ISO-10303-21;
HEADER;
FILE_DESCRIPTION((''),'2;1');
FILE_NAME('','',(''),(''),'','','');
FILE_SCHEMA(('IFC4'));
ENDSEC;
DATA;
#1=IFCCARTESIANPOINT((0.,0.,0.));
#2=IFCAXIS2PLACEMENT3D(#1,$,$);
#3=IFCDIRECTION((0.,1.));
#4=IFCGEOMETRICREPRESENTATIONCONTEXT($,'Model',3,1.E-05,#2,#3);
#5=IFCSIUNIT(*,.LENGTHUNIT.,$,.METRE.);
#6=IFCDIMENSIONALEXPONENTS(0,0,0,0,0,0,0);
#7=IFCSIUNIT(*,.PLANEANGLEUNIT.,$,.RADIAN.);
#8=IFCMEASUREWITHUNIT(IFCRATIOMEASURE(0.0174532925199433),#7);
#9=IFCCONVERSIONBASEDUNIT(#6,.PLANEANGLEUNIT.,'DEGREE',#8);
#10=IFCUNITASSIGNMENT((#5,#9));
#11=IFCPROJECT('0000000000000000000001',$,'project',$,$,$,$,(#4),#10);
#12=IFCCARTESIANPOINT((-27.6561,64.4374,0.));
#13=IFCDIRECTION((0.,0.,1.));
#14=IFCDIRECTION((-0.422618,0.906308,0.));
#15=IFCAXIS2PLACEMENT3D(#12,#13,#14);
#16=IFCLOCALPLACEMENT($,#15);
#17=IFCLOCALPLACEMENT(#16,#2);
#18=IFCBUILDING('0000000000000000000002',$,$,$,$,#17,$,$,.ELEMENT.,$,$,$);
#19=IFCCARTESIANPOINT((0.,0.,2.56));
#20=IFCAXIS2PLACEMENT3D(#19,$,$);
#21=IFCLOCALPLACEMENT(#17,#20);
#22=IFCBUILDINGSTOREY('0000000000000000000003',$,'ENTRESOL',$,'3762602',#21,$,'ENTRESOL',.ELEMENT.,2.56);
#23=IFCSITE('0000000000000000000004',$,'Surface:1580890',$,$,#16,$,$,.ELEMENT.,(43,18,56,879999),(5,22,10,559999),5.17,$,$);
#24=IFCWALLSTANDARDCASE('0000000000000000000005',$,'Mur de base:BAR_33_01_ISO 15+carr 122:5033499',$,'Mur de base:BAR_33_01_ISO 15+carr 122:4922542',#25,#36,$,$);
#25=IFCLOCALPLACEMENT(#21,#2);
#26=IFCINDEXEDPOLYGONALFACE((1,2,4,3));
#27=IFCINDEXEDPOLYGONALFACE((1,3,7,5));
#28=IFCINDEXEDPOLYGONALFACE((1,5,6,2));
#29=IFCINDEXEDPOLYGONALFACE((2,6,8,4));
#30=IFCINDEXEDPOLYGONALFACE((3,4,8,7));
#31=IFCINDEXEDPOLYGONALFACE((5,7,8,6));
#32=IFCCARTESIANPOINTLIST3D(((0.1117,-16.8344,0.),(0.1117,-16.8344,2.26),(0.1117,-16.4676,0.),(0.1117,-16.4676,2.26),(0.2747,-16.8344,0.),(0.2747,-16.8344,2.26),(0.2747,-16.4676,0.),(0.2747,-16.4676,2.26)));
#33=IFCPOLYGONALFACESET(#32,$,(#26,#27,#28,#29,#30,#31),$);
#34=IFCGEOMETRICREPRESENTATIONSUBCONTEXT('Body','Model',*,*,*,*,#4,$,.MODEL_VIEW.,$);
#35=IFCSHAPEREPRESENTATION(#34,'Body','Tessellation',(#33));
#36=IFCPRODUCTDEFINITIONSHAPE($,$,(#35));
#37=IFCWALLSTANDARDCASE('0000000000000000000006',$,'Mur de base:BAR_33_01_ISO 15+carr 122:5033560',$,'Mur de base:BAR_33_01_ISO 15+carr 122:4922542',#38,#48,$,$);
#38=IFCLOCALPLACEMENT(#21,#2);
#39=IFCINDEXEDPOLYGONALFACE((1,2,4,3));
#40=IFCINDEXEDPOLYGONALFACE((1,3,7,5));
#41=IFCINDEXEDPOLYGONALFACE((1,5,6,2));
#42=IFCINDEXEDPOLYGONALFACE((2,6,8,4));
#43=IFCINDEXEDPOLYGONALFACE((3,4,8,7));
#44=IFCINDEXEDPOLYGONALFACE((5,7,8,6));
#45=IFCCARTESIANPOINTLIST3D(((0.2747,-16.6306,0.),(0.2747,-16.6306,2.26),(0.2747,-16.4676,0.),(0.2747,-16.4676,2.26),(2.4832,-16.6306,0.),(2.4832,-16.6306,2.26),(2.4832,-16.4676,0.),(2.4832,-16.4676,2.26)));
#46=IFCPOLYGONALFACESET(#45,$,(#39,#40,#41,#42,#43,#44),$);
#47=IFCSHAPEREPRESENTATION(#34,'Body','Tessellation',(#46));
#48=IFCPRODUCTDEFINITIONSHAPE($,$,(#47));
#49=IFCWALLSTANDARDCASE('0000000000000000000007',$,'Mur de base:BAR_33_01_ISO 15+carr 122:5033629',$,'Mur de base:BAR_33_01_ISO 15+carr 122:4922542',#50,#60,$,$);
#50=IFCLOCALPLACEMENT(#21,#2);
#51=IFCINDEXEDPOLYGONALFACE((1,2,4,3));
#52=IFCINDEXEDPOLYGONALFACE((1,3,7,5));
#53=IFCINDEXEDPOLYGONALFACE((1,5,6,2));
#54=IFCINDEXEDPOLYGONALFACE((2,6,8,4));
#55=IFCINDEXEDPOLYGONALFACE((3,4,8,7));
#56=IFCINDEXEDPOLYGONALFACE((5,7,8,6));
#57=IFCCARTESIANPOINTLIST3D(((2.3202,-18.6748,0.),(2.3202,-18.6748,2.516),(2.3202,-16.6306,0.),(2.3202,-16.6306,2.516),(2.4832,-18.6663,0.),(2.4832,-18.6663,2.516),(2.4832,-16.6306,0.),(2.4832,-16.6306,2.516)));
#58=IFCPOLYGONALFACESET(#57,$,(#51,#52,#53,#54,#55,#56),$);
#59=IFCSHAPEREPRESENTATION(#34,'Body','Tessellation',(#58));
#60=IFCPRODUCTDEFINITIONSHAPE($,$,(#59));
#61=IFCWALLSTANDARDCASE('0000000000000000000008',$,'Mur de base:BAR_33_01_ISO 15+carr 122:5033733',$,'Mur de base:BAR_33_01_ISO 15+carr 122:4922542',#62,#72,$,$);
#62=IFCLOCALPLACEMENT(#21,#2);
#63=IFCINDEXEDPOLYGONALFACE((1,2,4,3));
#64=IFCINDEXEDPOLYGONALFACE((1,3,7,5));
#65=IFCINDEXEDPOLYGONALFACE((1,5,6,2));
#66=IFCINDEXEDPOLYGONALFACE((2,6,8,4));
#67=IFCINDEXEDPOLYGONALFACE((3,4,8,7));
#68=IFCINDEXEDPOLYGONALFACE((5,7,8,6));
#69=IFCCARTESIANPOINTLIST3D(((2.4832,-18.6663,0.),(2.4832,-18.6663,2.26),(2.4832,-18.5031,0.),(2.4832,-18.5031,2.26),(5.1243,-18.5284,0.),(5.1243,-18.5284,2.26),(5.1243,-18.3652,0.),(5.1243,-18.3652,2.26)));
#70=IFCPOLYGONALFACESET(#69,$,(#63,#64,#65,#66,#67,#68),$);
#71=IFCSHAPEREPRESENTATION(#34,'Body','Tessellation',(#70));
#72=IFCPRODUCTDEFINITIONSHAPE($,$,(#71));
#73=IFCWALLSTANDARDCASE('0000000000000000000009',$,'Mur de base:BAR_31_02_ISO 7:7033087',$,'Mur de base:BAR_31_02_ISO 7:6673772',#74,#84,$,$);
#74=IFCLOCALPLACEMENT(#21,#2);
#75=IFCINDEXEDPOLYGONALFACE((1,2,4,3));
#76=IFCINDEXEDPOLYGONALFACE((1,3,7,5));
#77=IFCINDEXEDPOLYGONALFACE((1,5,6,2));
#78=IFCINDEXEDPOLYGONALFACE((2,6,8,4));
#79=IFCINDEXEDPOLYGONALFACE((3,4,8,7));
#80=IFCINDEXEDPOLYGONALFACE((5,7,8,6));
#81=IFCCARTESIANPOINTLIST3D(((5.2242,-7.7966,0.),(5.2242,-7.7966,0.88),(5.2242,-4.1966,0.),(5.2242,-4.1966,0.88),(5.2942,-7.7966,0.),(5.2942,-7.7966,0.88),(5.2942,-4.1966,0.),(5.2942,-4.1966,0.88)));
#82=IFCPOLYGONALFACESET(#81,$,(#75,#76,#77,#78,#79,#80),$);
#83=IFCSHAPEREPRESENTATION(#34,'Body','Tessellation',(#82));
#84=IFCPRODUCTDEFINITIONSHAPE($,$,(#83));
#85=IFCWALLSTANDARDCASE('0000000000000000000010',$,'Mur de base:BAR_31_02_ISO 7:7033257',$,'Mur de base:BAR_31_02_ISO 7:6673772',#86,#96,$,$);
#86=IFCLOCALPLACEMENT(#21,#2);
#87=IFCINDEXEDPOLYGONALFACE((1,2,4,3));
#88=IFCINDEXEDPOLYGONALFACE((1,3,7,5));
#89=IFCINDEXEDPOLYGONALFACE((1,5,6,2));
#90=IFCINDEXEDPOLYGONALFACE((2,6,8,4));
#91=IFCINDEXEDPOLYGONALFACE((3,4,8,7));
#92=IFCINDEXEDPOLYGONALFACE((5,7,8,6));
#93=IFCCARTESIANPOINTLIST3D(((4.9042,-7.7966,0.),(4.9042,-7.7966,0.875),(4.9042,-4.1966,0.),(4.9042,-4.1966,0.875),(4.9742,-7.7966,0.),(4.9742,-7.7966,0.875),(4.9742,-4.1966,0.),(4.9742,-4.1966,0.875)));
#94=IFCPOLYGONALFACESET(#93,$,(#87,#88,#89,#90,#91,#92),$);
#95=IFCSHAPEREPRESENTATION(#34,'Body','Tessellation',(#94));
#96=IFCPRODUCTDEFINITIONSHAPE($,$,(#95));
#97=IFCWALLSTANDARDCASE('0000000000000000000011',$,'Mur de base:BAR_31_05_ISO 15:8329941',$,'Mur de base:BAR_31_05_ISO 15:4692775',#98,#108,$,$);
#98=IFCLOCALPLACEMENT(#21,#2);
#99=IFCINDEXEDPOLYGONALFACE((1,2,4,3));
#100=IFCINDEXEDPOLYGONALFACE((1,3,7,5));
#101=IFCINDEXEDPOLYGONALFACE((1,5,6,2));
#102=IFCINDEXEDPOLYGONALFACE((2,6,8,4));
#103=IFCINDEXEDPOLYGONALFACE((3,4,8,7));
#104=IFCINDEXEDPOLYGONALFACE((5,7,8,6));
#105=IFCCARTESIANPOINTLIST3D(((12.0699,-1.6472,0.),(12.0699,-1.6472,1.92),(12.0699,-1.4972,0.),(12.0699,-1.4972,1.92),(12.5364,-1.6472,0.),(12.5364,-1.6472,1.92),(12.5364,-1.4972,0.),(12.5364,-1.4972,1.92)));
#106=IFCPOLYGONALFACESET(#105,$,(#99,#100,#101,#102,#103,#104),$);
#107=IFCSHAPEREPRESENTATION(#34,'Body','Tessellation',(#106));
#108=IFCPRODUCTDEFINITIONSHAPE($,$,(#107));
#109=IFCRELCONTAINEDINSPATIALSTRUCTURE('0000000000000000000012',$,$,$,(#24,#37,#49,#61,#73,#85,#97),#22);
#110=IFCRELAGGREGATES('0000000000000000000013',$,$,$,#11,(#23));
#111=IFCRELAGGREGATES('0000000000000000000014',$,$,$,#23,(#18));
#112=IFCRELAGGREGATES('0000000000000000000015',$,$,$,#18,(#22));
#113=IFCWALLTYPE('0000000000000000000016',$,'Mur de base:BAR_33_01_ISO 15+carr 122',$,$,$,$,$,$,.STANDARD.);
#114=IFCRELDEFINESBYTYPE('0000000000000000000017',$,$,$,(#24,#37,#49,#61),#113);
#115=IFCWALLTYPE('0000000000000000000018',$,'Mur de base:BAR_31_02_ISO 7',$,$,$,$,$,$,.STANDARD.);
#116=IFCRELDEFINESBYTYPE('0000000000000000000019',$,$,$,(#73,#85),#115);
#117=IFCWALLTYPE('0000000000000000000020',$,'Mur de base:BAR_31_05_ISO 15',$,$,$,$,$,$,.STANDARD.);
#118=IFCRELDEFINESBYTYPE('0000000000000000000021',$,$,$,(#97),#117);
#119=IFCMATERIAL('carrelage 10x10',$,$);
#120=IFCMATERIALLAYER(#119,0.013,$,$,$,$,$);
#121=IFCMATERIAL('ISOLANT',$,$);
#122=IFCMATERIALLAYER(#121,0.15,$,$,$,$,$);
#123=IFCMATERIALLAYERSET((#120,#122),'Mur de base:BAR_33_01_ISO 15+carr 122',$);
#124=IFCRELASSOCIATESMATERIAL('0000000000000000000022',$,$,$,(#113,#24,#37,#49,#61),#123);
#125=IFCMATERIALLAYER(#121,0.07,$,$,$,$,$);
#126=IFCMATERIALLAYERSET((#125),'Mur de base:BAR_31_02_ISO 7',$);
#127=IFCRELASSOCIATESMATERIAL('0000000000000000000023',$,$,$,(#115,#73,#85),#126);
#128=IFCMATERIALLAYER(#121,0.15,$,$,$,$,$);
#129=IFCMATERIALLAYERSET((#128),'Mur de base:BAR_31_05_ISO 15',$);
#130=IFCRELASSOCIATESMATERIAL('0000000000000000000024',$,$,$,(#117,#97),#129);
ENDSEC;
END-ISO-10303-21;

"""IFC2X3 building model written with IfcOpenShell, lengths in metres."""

from ifc_helpers import new_model, entity, si_unit, converted_unit, direction, frame, frame_2d, origin, place, context, subcontext, project, spatial, polyline, rectangle, outline, extrude, clip, halfspace, material, layer, layer_set, layer_usage, type_object, element, save


model = new_model("IFC2X3")

# Units and contexts
model_context = context("Model", 3, precision=1e-05, world=origin(), true_north=direction((0.0, 1.0)))
body_context = subcontext(model_context, "Body", "Model", "MODEL_VIEW")
ifc_project = project(units=[si_unit("LENGTHUNIT", "METRE"), converted_unit("PLANEANGLEUNIT", "DEGREE", entity("IfcRatioMeasure", 0.0174532925199433), si_unit("PLANEANGLEUNIT", "RADIAN"), dimensions=[0, 0, 0, 0, 0, 0, 0])], contexts=[model_context])

# Site, building, storey
site_placement = place(None, frame((-27.6561, 64.4374, 0.0), z_axis=(0.0, 0.0, 1.0), x_axis=(-0.422618, 0.906308, 0.0)))
site = spatial("IfcSite", under=ifc_project, at=site_placement, Name="Surface:1580890", CompositionType="ELEMENT", RefLatitude=(43, 18, 56, 879999), RefLongitude=(5, 22, 10, 559999), RefElevation=5.17)
building_placement = place(site_placement, origin())
building = spatial("IfcBuilding", under=site, at=building_placement, CompositionType="ELEMENT")
storey_placement = place(building_placement, frame((0.0, 0.0, 2.56)))
storey = spatial("IfcBuildingStorey", under=building, at=storey_placement, Name="ENTRESOL", ObjectType="3762602", LongName="ENTRESOL", CompositionType="ELEMENT", Elevation=2.56)

# Walls
ifc_material_1 = material(Name="ISOLANT")
ifc_material_2 = material(Name="carrelage 10x10")
ifc_layer_1 = layer(ifc_material_2, 0.013)
ifc_layer_2 = layer(ifc_material_1, 0.15)
ifc_layer_set_1 = layer_set([ifc_layer_1, ifc_layer_2], Name="Mur de base:BAR_33_01_ISO 15+carr 122")
wall_type_1 = type_object("IfcWallType", Name="Mur de base:BAR_33_01_ISO 15+carr 122", PredefinedType="STANDARD", material=ifc_layer_set_1)
ifc_layer_usage_1 = layer_usage(ifc_layer_set_1, "AXIS2", "NEGATIVE", 0.0815)
wall_1_placement = place(storey_placement, frame((0.1932, -16.8344, 0.0), z_axis=(0.0, 0.0, 1.0), x_axis=(0.0, 1.0, 0.0)))
element("IfcWallStandardCase", 1, at=wall_1_placement, inside=storey, type_object=wall_type_1, material=ifc_layer_usage_1, Name="Mur de base:BAR_33_01_ISO 15+carr 122:5033499", ObjectType="Mur de base:BAR_33_01_ISO 15+carr 122:4922542", context=body_context, shape_type="Clipping", body=[
    clip(extrude(rectangle(XDim=0.3669, YDim=0.163, at=frame_2d((0.1834, 0.0), x_axis=(-1.0, 0.0))), origin(), (0.0, 0.0, 1.0), 2.26), halfspace(frame((0.0, 0.0, -2.56)), True)),
])
ifc_layer_usage_2 = layer_usage(ifc_layer_set_1, "AXIS2", "NEGATIVE", 0.0815)
wall_2_placement = place(storey_placement, frame((0.2747, -16.5491, 0.0)))
element("IfcWallStandardCase", 2, at=wall_2_placement, inside=storey, type_object=wall_type_1, material=ifc_layer_usage_2, Name="Mur de base:BAR_33_01_ISO 15+carr 122:5033560", ObjectType="Mur de base:BAR_33_01_ISO 15+carr 122:4922542", context=body_context, shape_type="Clipping", body=[
    clip(extrude(rectangle(XDim=2.2084, YDim=0.163, at=frame_2d((1.1042, 0.0), x_axis=(-1.0, 0.0))), origin(), (0.0, 0.0, 1.0), 2.26), halfspace(frame((0.0, 0.0, -2.56)), True)),
])
ifc_layer_usage_3 = layer_usage(ifc_layer_set_1, "AXIS2", "NEGATIVE", 0.0815)
wall_3_placement = place(storey_placement, frame((2.4017, -16.6306, 0.0), z_axis=(0.0, 0.0, 1.0), x_axis=(0.0, -1.0, 0.0)))
element("IfcWallStandardCase", 3, at=wall_3_placement, inside=storey, type_object=wall_type_1, material=ifc_layer_usage_3, Name="Mur de base:BAR_33_01_ISO 15+carr 122:5033629", ObjectType="Mur de base:BAR_33_01_ISO 15+carr 122:4922542", context=body_context, shape_type="Clipping", body=[
    clip(extrude(outline(polyline([(2.0442, -0.0815), (2.0357, 0.0815), (1.8725, 0.0815), (0.0, 0.0815), (0.0, -0.0815), (2.0442, -0.0815)])), origin(), (0.0, 0.0, 1.0), 2.516), halfspace(frame((0.0, 0.0, -2.56)), True)),
])
ifc_layer_usage_4 = layer_usage(ifc_layer_set_1, "AXIS2", "NEGATIVE", 0.0815)
wall_4_placement = place(storey_placement, frame((2.4789, -18.5849, 0.0), z_axis=(0.0, 0.0, 1.0), x_axis=(0.998641, 0.05212, 0.0)))
element("IfcWallStandardCase", 4, at=wall_4_placement, inside=storey, type_object=wall_type_1, material=ifc_layer_usage_4, Name="Mur de base:BAR_33_01_ISO 15+carr 122:5033733", ObjectType="Mur de base:BAR_33_01_ISO 15+carr 122:4922542", context=body_context, shape_type="Clipping", body=[
    clip(extrude(outline(polyline([(2.6448, -0.0815), (2.6533, 0.0815), (0.0085, 0.0815), (0.0, -0.0815), (2.6448, -0.0815)])), origin(), (0.0, 0.0, 1.0), 2.26), halfspace(frame((0.0, 0.0, -2.56)), True)),
])
ifc_layer_3 = layer(ifc_material_1, 0.07)
ifc_layer_set_2 = layer_set([ifc_layer_3], Name="Mur de base:BAR_31_02_ISO 7")
ifc_layer_usage_5 = layer_usage(ifc_layer_set_2, "AXIS2", "NEGATIVE", 0.035)
wall_type_2 = type_object("IfcWallType", Name="Mur de base:BAR_31_02_ISO 7", PredefinedType="STANDARD", material=ifc_layer_set_2)
wall_5_placement = place(storey_placement, frame((5.2592, -4.1966, 0.0), z_axis=(0.0, 0.0, 1.0), x_axis=(0.0, -1.0, 0.0)))
element("IfcWallStandardCase", 5, at=wall_5_placement, inside=storey, type_object=wall_type_2, material=ifc_layer_usage_5, Name="Mur de base:BAR_31_02_ISO 7:7033087", ObjectType="Mur de base:BAR_31_02_ISO 7:6673772", context=body_context, shape_type="Clipping", body=[
    clip(extrude(rectangle(XDim=3.6, YDim=0.07, at=frame_2d((1.8, 0.0), x_axis=(-1.0, 0.0))), origin(), (0.0, 0.0, 1.0), 0.88), halfspace(frame((0.0, 0.0, -2.56)), True)),
])
ifc_layer_usage_6 = layer_usage(ifc_layer_set_2, "AXIS2", "POSITIVE", -0.035)
wall_6_placement = place(storey_placement, frame((4.9392, -4.1966, 0.0), z_axis=(0.0, 0.0, 1.0), x_axis=(0.0, -1.0, 0.0)))
element("IfcWallStandardCase", 6, at=wall_6_placement, inside=storey, type_object=wall_type_2, material=ifc_layer_usage_6, Name="Mur de base:BAR_31_02_ISO 7:7033257", ObjectType="Mur de base:BAR_31_02_ISO 7:6673772", context=body_context, shape_type="Clipping", body=[
    clip(extrude(rectangle(XDim=3.6, YDim=0.07, at=frame_2d((1.8, 0.0), x_axis=(-1.0, 0.0))), origin(), (0.0, 0.0, 1.0), 0.875), halfspace(frame((0.0, 0.0, -2.56)), True)),
])
ifc_layer_4 = layer(ifc_material_1, 0.15)
ifc_layer_set_3 = layer_set([ifc_layer_4], Name="Mur de base:BAR_31_05_ISO 15")
ifc_layer_usage_7 = layer_usage(ifc_layer_set_3, "AXIS2", "NEGATIVE", 0.075)
wall_type_3 = type_object("IfcWallType", Name="Mur de base:BAR_31_05_ISO 15", PredefinedType="STANDARD", material=ifc_layer_set_3)
wall_7_placement = place(storey_placement, frame((12.5364, -1.5722, 0.0), z_axis=(0.0, 0.0, 1.0), x_axis=(-1.0, 0.0, 0.0)))
element("IfcWallStandardCase", 7, at=wall_7_placement, inside=storey, type_object=wall_type_3, material=ifc_layer_usage_7, Name="Mur de base:BAR_31_05_ISO 15:8329941", ObjectType="Mur de base:BAR_31_05_ISO 15:4692775", context=body_context, shape_type="Clipping", body=[
    clip(extrude(rectangle(XDim=0.4665, YDim=0.15, at=frame_2d((0.2332, 0.0), x_axis=(-1.0, 0.0))), origin(), (0.0, 0.0, 1.0), 1.92), halfspace(frame((0.0, 0.0, -2.56)), True)),
])

save(model, "model.ifc")
